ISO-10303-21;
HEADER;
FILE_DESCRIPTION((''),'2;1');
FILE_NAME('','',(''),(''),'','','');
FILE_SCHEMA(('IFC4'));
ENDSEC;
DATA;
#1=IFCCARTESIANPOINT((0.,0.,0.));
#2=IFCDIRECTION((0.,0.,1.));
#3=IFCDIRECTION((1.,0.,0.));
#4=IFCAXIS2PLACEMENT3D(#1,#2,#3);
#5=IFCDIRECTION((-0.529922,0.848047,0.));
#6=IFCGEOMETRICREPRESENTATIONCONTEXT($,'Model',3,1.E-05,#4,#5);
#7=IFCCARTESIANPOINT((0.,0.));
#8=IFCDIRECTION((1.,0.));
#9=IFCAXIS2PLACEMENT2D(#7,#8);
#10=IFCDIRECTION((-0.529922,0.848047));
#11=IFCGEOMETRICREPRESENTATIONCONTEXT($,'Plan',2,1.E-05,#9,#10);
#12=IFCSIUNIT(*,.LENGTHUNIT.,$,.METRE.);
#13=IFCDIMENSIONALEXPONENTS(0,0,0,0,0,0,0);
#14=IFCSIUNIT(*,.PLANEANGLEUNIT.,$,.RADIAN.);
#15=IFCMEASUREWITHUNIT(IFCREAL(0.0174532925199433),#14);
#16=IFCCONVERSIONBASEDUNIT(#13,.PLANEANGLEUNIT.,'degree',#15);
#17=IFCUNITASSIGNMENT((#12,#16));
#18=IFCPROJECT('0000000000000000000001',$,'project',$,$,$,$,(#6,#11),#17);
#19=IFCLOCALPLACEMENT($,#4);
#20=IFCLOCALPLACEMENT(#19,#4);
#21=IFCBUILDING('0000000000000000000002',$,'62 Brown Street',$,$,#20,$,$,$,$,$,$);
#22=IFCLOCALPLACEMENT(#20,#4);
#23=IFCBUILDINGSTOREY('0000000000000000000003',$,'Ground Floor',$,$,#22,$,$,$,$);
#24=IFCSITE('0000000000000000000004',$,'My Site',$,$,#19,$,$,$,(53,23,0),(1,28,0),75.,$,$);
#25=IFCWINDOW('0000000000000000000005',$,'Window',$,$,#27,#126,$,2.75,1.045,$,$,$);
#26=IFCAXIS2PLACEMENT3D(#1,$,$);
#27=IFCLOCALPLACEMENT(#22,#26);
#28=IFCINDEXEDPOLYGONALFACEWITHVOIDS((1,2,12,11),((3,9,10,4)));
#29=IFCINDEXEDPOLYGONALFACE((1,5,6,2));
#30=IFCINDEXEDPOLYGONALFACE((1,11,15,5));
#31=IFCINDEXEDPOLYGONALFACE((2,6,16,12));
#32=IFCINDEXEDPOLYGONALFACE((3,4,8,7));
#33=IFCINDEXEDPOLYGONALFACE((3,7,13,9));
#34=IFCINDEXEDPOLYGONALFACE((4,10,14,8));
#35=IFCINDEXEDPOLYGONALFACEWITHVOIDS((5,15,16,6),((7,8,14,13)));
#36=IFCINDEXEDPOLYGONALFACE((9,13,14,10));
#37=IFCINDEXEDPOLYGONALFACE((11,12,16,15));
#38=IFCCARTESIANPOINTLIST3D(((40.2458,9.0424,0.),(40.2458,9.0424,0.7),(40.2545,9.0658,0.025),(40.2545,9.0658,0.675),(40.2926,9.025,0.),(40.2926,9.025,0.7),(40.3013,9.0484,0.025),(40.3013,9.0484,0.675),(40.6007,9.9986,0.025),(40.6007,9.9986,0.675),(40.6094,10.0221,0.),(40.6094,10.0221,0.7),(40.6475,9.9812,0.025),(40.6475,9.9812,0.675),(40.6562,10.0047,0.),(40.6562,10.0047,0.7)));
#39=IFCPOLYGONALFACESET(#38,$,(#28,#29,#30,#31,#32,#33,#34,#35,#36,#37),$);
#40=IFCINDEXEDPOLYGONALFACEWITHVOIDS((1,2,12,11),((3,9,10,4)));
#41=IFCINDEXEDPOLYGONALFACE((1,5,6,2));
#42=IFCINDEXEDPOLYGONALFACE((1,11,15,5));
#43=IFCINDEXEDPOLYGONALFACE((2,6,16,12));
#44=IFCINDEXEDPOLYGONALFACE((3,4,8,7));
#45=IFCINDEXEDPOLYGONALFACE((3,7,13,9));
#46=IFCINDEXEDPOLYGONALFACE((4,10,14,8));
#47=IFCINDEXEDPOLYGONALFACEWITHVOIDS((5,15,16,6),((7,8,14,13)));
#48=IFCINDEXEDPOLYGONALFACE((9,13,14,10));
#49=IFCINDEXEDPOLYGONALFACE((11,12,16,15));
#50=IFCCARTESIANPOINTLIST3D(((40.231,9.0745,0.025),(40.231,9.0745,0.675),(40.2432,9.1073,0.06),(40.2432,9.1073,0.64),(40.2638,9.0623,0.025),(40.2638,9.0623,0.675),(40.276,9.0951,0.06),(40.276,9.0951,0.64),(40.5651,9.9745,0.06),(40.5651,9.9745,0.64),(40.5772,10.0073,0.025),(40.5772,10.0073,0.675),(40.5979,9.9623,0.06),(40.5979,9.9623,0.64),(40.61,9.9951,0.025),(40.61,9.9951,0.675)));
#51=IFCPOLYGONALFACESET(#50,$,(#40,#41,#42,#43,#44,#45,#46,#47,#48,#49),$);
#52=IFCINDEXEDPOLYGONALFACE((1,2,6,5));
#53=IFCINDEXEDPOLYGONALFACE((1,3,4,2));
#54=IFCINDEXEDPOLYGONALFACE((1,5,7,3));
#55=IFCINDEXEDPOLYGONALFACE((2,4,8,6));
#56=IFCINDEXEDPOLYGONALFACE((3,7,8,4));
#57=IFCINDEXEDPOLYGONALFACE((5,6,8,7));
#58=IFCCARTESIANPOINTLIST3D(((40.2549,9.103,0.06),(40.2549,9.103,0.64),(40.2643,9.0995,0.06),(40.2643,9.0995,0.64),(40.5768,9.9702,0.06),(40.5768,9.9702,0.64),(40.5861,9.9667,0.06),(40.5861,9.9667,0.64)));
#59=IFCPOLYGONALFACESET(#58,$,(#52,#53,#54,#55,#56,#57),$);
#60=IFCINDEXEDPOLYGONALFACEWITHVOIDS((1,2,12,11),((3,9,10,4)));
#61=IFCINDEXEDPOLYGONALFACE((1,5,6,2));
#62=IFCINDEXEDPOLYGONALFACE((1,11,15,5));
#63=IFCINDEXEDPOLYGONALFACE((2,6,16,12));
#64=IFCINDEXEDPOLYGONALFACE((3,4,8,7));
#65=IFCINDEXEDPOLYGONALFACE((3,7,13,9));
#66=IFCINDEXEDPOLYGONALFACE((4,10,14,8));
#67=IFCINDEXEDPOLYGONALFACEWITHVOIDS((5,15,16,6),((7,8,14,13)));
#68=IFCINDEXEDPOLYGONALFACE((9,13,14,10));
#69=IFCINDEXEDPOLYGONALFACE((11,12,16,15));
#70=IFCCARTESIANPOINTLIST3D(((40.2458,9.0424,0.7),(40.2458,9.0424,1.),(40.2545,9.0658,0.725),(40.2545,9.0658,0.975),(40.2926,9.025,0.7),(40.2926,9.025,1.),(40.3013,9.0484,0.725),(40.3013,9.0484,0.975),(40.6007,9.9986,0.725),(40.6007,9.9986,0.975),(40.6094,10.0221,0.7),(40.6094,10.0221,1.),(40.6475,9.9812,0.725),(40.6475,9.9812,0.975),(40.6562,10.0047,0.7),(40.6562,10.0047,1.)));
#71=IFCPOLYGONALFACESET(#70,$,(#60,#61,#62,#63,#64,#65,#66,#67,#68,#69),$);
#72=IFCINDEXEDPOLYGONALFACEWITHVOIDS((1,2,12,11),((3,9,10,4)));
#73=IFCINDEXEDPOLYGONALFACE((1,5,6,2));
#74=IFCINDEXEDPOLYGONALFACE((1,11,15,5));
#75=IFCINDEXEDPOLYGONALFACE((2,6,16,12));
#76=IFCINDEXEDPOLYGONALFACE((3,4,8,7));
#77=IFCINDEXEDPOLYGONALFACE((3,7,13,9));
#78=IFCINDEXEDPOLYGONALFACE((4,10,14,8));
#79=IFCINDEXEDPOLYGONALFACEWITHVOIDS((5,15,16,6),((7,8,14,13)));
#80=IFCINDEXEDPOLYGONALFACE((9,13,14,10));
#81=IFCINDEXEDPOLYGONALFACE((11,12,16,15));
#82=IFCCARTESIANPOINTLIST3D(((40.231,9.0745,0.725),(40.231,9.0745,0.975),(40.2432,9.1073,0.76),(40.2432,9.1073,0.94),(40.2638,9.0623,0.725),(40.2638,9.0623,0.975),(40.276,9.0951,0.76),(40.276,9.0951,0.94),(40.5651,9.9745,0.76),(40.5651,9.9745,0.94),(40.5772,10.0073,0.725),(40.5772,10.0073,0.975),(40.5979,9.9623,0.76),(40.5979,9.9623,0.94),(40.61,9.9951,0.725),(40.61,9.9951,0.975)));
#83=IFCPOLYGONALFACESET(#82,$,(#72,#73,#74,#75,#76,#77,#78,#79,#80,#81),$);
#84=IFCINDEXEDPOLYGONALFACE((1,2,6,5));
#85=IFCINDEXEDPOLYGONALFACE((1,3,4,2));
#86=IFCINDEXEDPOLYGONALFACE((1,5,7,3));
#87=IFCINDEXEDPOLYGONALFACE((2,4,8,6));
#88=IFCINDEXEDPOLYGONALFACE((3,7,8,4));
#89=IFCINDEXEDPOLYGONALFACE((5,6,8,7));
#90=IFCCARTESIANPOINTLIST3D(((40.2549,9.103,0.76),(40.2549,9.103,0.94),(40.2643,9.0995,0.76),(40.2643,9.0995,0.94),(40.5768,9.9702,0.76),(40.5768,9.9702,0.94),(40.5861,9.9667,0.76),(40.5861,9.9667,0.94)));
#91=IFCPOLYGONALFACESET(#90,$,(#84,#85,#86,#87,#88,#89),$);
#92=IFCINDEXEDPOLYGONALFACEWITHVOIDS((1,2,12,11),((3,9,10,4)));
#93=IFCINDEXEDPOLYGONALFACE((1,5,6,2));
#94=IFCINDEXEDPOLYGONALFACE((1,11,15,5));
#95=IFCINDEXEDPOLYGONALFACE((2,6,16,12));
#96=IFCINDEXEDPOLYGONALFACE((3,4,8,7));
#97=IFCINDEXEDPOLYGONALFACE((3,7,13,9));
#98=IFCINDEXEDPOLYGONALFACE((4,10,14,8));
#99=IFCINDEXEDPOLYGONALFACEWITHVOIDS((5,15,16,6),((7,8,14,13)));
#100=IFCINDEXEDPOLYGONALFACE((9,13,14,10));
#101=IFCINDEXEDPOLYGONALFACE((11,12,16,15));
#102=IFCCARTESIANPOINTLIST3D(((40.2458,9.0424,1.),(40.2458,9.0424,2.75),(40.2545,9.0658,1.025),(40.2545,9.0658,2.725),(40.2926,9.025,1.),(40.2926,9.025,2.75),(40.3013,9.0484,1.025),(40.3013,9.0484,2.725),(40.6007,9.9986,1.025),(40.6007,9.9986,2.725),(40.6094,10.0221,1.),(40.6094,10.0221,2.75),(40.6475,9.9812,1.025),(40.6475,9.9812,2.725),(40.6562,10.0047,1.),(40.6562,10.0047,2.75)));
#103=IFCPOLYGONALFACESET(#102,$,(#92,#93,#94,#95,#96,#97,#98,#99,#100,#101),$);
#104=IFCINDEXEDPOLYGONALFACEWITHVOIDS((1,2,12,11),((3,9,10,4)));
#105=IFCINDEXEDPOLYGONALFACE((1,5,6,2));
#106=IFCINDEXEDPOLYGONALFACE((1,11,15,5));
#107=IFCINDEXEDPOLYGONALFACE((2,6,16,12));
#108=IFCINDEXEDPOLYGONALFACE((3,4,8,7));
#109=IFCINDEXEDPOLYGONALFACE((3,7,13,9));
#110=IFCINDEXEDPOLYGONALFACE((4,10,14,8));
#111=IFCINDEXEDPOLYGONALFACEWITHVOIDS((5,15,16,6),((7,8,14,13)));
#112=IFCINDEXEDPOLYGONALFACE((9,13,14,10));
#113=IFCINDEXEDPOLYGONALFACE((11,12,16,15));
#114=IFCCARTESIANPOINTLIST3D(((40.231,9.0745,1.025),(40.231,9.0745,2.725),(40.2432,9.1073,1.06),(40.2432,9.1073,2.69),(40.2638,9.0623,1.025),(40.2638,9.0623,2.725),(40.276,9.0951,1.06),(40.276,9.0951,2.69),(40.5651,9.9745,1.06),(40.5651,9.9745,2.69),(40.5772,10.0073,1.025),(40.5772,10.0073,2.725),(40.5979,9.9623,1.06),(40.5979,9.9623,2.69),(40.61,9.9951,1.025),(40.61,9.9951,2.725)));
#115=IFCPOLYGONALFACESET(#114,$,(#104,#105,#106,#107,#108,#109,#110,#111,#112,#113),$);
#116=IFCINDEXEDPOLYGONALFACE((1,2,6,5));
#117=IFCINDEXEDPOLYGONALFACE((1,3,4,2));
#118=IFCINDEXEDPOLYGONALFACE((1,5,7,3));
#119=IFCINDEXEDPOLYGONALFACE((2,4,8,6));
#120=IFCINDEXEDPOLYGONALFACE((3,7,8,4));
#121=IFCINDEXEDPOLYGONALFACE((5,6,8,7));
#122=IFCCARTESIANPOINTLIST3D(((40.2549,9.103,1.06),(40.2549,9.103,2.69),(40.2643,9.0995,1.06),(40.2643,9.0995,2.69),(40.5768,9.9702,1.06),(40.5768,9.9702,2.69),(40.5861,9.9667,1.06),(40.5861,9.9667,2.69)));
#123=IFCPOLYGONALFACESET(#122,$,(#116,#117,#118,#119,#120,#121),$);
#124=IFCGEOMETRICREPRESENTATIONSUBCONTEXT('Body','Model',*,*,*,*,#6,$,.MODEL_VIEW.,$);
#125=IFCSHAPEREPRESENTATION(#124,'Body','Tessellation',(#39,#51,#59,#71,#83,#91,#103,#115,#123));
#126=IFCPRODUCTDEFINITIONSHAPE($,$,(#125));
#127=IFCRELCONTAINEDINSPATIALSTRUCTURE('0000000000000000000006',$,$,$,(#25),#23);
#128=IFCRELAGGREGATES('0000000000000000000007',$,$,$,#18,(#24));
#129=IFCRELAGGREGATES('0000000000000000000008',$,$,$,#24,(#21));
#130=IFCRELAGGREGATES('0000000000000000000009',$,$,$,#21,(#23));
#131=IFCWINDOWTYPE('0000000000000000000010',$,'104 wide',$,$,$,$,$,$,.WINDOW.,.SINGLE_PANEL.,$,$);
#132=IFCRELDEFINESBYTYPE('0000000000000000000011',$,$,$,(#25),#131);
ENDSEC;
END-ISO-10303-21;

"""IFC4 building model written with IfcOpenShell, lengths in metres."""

from ifc_helpers import new_model, entity, si_unit, converted_unit, direction, frame, origin_with_axes, origin_2d_with_axis, place, context, subcontext, project, spatial, line, indexed_curve, outline, extrude, shape, source, transform, mapped, type_object, type_shapes, element, save


model = new_model("IFC4")

# Units and contexts
model_context = context("Model", 3, precision=1e-05, world=origin_with_axes(), true_north=direction((-0.529922, 0.848047, 0.0)))
plan_context = context("Plan", 2, precision=1e-05, world=origin_2d_with_axis(), true_north=direction((-0.529922, 0.848047)))
body_context_1 = subcontext(model_context, "Body", "Model", "MODEL_VIEW")
body_context_2 = subcontext(plan_context, "Body", "Plan", "PLAN_VIEW")
ifc_project = project(units=[si_unit("LENGTHUNIT", "METRE"), converted_unit("PLANEANGLEUNIT", "degree", entity("IfcReal", 0.0174532925199433), si_unit("PLANEANGLEUNIT", "RADIAN"), dimensions=[0, 0, 0, 0, 0, 0, 0])], contexts=[model_context, plan_context])

# Site, building, storey
site_placement = place(None, origin_with_axes())
site = spatial("IfcSite", under=ifc_project, at=site_placement, Name="My Site", RefLatitude=(53, 23, 0), RefLongitude=(1, 28, 0), RefElevation=75.0)
building_placement = place(site_placement, origin_with_axes())
building = spatial("IfcBuilding", under=site, at=building_placement, Name="62 Brown Street")
storey_placement = place(building_placement, origin_with_axes())
storey = spatial("IfcBuildingStorey", under=building, at=storey_placement, Name="Ground Floor")

# Window
window_type_1 = type_object("IfcWindowType", Name="104 wide", PartitioningType="SINGLE_PANEL", PredefinedType="WINDOW")
shared_shape_1 = source(origin_with_axes(), body_context_1, "Body", "SweptSolid", [
    extrude(outline(indexed_curve([(0.0, 0.0), (1.045, 0.0), (1.045, 0.7), (0.0, 0.7)], segments=[line(1, 2, 3, 4, 1)]), holes=[indexed_curve([(0.025, 0.025), (1.02, 0.025), (1.02, 0.675), (0.025, 0.675)], segments=[line(1, 2, 3, 4, 1)])]), frame((0.0, 0.15, 0.0), z_axis=(0.0, -1.0, 0.0), x_axis=(1.0, 0.0, 0.0)), (0.0, 0.0, -1.0), 0.05),
    extrude(outline(indexed_curve([(0.0, 0.0), (0.995, 0.0), (0.995, 0.65), (0.0, 0.65)], segments=[line(1, 2, 3, 4, 1)]), holes=[indexed_curve([(0.035, 0.035), (0.96, 0.035), (0.96, 0.615), (0.035, 0.615)], segments=[line(1, 2, 3, 4, 1)])]), frame((0.025, 0.19, 0.025), z_axis=(0.0, -1.0, 0.0), x_axis=(1.0, 0.0, 0.0)), (0.0, 0.0, -1.0), 0.035),
    extrude(outline(indexed_curve([(0.035, 0.035), (0.96, 0.035), (0.96, 0.615), (0.035, 0.615)], segments=[line(1, 2, 3, 4, 1)])), frame((0.025, 0.2025, 0.025), z_axis=(0.0, -1.0, 0.0), x_axis=(1.0, 0.0, 0.0)), (0.0, 0.0, -1.0), 0.01),
    extrude(outline(indexed_curve([(0.0, 0.0), (1.045, 0.0), (1.045, 0.3), (0.0, 0.3)], segments=[line(1, 2, 3, 4, 1)]), holes=[indexed_curve([(0.025, 0.025), (1.02, 0.025), (1.02, 0.275), (0.025, 0.275)], segments=[line(1, 2, 3, 4, 1)])]), frame((0.0, 0.15, 0.7), z_axis=(0.0, -1.0, 0.0), x_axis=(1.0, 0.0, 0.0)), (0.0, 0.0, -1.0), 0.05),
    extrude(outline(indexed_curve([(0.0, 0.0), (0.995, 0.0), (0.995, 0.25), (0.0, 0.25)], segments=[line(1, 2, 3, 4, 1)]), holes=[indexed_curve([(0.035, 0.035), (0.96, 0.035), (0.96, 0.215), (0.035, 0.215)], segments=[line(1, 2, 3, 4, 1)])]), frame((0.025, 0.19, 0.725), z_axis=(0.0, -1.0, 0.0), x_axis=(1.0, 0.0, 0.0)), (0.0, 0.0, -1.0), 0.035),
    extrude(outline(indexed_curve([(0.035, 0.035), (0.96, 0.035), (0.96, 0.215), (0.035, 0.215)], segments=[line(1, 2, 3, 4, 1)])), frame((0.025, 0.2025, 0.725), z_axis=(0.0, -1.0, 0.0), x_axis=(1.0, 0.0, 0.0)), (0.0, 0.0, -1.0), 0.01),
    extrude(outline(indexed_curve([(0.0, 0.0), (1.045, 0.0), (1.045, 1.75), (0.0, 1.75)], segments=[line(1, 2, 3, 4, 1)]), holes=[indexed_curve([(0.025, 0.025), (1.02, 0.025), (1.02, 1.725), (0.025, 1.725)], segments=[line(1, 2, 3, 4, 1)])]), frame((0.0, 0.15, 1.0), z_axis=(0.0, -1.0, 0.0), x_axis=(1.0, 0.0, 0.0)), (0.0, 0.0, -1.0), 0.05),
    extrude(outline(indexed_curve([(0.0, 0.0), (0.995, 0.0), (0.995, 1.7), (0.0, 1.7)], segments=[line(1, 2, 3, 4, 1)]), holes=[indexed_curve([(0.035, 0.035), (0.96, 0.035), (0.96, 1.665), (0.035, 1.665)], segments=[line(1, 2, 3, 4, 1)])]), frame((0.025, 0.19, 1.025), z_axis=(0.0, -1.0, 0.0), x_axis=(1.0, 0.0, 0.0)), (0.0, 0.0, -1.0), 0.035),
    extrude(outline(indexed_curve([(0.035, 0.035), (0.96, 0.035), (0.96, 1.665), (0.035, 1.665)], segments=[line(1, 2, 3, 4, 1)])), frame((0.025, 0.2025, 1.025), z_axis=(0.0, -1.0, 0.0), x_axis=(1.0, 0.0, 0.0)), (0.0, 0.0, -1.0), 0.01),
])
shared_shape_2 = source(origin_with_axes(), body_context_2, "Body", "Curve2D", [
    entity("IfcIndexedPolyCurve", entity("IfcCartesianPointList2D", [[0.025, 0.15], [1.02, 0.15]])),
    entity("IfcIndexedPolyCurve", entity("IfcCartesianPointList2D", [[0.0, 0.2], [0.025, 0.2], [0.025, 0.15], [0.0, 0.15]]), [entity("IfcLineIndex", [1, 2, 3, 4, 1])]),
    entity("IfcIndexedPolyCurve", entity("IfcCartesianPointList2D", [[1.045, 0.2], [1.02, 0.2], [1.02, 0.15], [1.045, 0.15]]), [entity("IfcLineIndex", [1, 2, 3, 4, 1])]),
    entity("IfcIndexedPolyCurve", entity("IfcCartesianPointList2D", [[0.025, 0.19], [0.06, 0.19], [0.06, 0.225], [0.025, 0.225]]), [entity("IfcLineIndex", [1, 2, 3, 4, 1])]),
    entity("IfcIndexedPolyCurve", entity("IfcCartesianPointList2D", [[1.02, 0.19], [0.985, 0.19], [0.985, 0.225], [1.02, 0.225]]), [entity("IfcLineIndex", [1, 2, 3, 4, 1])]),
    entity("IfcIndexedPolyCurve", entity("IfcCartesianPointList2D", [[0.06, 0.19], [0.985, 0.19]])),
    entity("IfcIndexedPolyCurve", entity("IfcCartesianPointList2D", [[0.06, 0.225], [0.985, 0.225]])),
    entity("IfcIndexedPolyCurve", entity("IfcCartesianPointList2D", [[0.06, 0.2075], [0.985, 0.2075]])),
])
type_shapes(window_type_1, [shared_shape_1, shared_shape_2])
placement_1 = place(storey_placement, frame((39.024, 5.1755, 0.0), z_axis=(0.0, 0.0, 1.0), x_axis=(0.347944, 0.937515, 0.0)))
placement_2 = place(placement_1, frame((4.0504, 0.0, 0.0), z_axis=(0.0, 0.0, 1.0), x_axis=(1.0, 0.0, 0.0)))
window_1_placement = place(placement_2, frame((0.0, 0.0, 0.0), z_axis=(0.0, 0.0, 1.0), x_axis=(1.0, 0.0, 0.0)))
element("IfcWindow", 1, at=window_1_placement, inside=storey, type_object=window_type_1, Name="Window", OverallHeight=2.75, OverallWidth=1.045, shapes=[
    shape(body_context_1, "Body", "MappedRepresentation", [mapped(shared_shape_1, transform((0.0, 0.0, 0.0), x_axis=(1.0, 0.0, 0.0), y_axis=(0.0, 1.0, 0.0), z_axis=(0.0, 0.0, 1.0), scale=1.0))]),
    shape(body_context_2, "Body", "MappedRepresentation", [mapped(shared_shape_2, transform((0.0, 0.0, 0.0), x_axis=(1.0, 0.0, 0.0), y_axis=(0.0, 1.0, 0.0), z_axis=(0.0, 0.0, 1.0), scale=1.0))]),
])

save(model, "model.ifc")
